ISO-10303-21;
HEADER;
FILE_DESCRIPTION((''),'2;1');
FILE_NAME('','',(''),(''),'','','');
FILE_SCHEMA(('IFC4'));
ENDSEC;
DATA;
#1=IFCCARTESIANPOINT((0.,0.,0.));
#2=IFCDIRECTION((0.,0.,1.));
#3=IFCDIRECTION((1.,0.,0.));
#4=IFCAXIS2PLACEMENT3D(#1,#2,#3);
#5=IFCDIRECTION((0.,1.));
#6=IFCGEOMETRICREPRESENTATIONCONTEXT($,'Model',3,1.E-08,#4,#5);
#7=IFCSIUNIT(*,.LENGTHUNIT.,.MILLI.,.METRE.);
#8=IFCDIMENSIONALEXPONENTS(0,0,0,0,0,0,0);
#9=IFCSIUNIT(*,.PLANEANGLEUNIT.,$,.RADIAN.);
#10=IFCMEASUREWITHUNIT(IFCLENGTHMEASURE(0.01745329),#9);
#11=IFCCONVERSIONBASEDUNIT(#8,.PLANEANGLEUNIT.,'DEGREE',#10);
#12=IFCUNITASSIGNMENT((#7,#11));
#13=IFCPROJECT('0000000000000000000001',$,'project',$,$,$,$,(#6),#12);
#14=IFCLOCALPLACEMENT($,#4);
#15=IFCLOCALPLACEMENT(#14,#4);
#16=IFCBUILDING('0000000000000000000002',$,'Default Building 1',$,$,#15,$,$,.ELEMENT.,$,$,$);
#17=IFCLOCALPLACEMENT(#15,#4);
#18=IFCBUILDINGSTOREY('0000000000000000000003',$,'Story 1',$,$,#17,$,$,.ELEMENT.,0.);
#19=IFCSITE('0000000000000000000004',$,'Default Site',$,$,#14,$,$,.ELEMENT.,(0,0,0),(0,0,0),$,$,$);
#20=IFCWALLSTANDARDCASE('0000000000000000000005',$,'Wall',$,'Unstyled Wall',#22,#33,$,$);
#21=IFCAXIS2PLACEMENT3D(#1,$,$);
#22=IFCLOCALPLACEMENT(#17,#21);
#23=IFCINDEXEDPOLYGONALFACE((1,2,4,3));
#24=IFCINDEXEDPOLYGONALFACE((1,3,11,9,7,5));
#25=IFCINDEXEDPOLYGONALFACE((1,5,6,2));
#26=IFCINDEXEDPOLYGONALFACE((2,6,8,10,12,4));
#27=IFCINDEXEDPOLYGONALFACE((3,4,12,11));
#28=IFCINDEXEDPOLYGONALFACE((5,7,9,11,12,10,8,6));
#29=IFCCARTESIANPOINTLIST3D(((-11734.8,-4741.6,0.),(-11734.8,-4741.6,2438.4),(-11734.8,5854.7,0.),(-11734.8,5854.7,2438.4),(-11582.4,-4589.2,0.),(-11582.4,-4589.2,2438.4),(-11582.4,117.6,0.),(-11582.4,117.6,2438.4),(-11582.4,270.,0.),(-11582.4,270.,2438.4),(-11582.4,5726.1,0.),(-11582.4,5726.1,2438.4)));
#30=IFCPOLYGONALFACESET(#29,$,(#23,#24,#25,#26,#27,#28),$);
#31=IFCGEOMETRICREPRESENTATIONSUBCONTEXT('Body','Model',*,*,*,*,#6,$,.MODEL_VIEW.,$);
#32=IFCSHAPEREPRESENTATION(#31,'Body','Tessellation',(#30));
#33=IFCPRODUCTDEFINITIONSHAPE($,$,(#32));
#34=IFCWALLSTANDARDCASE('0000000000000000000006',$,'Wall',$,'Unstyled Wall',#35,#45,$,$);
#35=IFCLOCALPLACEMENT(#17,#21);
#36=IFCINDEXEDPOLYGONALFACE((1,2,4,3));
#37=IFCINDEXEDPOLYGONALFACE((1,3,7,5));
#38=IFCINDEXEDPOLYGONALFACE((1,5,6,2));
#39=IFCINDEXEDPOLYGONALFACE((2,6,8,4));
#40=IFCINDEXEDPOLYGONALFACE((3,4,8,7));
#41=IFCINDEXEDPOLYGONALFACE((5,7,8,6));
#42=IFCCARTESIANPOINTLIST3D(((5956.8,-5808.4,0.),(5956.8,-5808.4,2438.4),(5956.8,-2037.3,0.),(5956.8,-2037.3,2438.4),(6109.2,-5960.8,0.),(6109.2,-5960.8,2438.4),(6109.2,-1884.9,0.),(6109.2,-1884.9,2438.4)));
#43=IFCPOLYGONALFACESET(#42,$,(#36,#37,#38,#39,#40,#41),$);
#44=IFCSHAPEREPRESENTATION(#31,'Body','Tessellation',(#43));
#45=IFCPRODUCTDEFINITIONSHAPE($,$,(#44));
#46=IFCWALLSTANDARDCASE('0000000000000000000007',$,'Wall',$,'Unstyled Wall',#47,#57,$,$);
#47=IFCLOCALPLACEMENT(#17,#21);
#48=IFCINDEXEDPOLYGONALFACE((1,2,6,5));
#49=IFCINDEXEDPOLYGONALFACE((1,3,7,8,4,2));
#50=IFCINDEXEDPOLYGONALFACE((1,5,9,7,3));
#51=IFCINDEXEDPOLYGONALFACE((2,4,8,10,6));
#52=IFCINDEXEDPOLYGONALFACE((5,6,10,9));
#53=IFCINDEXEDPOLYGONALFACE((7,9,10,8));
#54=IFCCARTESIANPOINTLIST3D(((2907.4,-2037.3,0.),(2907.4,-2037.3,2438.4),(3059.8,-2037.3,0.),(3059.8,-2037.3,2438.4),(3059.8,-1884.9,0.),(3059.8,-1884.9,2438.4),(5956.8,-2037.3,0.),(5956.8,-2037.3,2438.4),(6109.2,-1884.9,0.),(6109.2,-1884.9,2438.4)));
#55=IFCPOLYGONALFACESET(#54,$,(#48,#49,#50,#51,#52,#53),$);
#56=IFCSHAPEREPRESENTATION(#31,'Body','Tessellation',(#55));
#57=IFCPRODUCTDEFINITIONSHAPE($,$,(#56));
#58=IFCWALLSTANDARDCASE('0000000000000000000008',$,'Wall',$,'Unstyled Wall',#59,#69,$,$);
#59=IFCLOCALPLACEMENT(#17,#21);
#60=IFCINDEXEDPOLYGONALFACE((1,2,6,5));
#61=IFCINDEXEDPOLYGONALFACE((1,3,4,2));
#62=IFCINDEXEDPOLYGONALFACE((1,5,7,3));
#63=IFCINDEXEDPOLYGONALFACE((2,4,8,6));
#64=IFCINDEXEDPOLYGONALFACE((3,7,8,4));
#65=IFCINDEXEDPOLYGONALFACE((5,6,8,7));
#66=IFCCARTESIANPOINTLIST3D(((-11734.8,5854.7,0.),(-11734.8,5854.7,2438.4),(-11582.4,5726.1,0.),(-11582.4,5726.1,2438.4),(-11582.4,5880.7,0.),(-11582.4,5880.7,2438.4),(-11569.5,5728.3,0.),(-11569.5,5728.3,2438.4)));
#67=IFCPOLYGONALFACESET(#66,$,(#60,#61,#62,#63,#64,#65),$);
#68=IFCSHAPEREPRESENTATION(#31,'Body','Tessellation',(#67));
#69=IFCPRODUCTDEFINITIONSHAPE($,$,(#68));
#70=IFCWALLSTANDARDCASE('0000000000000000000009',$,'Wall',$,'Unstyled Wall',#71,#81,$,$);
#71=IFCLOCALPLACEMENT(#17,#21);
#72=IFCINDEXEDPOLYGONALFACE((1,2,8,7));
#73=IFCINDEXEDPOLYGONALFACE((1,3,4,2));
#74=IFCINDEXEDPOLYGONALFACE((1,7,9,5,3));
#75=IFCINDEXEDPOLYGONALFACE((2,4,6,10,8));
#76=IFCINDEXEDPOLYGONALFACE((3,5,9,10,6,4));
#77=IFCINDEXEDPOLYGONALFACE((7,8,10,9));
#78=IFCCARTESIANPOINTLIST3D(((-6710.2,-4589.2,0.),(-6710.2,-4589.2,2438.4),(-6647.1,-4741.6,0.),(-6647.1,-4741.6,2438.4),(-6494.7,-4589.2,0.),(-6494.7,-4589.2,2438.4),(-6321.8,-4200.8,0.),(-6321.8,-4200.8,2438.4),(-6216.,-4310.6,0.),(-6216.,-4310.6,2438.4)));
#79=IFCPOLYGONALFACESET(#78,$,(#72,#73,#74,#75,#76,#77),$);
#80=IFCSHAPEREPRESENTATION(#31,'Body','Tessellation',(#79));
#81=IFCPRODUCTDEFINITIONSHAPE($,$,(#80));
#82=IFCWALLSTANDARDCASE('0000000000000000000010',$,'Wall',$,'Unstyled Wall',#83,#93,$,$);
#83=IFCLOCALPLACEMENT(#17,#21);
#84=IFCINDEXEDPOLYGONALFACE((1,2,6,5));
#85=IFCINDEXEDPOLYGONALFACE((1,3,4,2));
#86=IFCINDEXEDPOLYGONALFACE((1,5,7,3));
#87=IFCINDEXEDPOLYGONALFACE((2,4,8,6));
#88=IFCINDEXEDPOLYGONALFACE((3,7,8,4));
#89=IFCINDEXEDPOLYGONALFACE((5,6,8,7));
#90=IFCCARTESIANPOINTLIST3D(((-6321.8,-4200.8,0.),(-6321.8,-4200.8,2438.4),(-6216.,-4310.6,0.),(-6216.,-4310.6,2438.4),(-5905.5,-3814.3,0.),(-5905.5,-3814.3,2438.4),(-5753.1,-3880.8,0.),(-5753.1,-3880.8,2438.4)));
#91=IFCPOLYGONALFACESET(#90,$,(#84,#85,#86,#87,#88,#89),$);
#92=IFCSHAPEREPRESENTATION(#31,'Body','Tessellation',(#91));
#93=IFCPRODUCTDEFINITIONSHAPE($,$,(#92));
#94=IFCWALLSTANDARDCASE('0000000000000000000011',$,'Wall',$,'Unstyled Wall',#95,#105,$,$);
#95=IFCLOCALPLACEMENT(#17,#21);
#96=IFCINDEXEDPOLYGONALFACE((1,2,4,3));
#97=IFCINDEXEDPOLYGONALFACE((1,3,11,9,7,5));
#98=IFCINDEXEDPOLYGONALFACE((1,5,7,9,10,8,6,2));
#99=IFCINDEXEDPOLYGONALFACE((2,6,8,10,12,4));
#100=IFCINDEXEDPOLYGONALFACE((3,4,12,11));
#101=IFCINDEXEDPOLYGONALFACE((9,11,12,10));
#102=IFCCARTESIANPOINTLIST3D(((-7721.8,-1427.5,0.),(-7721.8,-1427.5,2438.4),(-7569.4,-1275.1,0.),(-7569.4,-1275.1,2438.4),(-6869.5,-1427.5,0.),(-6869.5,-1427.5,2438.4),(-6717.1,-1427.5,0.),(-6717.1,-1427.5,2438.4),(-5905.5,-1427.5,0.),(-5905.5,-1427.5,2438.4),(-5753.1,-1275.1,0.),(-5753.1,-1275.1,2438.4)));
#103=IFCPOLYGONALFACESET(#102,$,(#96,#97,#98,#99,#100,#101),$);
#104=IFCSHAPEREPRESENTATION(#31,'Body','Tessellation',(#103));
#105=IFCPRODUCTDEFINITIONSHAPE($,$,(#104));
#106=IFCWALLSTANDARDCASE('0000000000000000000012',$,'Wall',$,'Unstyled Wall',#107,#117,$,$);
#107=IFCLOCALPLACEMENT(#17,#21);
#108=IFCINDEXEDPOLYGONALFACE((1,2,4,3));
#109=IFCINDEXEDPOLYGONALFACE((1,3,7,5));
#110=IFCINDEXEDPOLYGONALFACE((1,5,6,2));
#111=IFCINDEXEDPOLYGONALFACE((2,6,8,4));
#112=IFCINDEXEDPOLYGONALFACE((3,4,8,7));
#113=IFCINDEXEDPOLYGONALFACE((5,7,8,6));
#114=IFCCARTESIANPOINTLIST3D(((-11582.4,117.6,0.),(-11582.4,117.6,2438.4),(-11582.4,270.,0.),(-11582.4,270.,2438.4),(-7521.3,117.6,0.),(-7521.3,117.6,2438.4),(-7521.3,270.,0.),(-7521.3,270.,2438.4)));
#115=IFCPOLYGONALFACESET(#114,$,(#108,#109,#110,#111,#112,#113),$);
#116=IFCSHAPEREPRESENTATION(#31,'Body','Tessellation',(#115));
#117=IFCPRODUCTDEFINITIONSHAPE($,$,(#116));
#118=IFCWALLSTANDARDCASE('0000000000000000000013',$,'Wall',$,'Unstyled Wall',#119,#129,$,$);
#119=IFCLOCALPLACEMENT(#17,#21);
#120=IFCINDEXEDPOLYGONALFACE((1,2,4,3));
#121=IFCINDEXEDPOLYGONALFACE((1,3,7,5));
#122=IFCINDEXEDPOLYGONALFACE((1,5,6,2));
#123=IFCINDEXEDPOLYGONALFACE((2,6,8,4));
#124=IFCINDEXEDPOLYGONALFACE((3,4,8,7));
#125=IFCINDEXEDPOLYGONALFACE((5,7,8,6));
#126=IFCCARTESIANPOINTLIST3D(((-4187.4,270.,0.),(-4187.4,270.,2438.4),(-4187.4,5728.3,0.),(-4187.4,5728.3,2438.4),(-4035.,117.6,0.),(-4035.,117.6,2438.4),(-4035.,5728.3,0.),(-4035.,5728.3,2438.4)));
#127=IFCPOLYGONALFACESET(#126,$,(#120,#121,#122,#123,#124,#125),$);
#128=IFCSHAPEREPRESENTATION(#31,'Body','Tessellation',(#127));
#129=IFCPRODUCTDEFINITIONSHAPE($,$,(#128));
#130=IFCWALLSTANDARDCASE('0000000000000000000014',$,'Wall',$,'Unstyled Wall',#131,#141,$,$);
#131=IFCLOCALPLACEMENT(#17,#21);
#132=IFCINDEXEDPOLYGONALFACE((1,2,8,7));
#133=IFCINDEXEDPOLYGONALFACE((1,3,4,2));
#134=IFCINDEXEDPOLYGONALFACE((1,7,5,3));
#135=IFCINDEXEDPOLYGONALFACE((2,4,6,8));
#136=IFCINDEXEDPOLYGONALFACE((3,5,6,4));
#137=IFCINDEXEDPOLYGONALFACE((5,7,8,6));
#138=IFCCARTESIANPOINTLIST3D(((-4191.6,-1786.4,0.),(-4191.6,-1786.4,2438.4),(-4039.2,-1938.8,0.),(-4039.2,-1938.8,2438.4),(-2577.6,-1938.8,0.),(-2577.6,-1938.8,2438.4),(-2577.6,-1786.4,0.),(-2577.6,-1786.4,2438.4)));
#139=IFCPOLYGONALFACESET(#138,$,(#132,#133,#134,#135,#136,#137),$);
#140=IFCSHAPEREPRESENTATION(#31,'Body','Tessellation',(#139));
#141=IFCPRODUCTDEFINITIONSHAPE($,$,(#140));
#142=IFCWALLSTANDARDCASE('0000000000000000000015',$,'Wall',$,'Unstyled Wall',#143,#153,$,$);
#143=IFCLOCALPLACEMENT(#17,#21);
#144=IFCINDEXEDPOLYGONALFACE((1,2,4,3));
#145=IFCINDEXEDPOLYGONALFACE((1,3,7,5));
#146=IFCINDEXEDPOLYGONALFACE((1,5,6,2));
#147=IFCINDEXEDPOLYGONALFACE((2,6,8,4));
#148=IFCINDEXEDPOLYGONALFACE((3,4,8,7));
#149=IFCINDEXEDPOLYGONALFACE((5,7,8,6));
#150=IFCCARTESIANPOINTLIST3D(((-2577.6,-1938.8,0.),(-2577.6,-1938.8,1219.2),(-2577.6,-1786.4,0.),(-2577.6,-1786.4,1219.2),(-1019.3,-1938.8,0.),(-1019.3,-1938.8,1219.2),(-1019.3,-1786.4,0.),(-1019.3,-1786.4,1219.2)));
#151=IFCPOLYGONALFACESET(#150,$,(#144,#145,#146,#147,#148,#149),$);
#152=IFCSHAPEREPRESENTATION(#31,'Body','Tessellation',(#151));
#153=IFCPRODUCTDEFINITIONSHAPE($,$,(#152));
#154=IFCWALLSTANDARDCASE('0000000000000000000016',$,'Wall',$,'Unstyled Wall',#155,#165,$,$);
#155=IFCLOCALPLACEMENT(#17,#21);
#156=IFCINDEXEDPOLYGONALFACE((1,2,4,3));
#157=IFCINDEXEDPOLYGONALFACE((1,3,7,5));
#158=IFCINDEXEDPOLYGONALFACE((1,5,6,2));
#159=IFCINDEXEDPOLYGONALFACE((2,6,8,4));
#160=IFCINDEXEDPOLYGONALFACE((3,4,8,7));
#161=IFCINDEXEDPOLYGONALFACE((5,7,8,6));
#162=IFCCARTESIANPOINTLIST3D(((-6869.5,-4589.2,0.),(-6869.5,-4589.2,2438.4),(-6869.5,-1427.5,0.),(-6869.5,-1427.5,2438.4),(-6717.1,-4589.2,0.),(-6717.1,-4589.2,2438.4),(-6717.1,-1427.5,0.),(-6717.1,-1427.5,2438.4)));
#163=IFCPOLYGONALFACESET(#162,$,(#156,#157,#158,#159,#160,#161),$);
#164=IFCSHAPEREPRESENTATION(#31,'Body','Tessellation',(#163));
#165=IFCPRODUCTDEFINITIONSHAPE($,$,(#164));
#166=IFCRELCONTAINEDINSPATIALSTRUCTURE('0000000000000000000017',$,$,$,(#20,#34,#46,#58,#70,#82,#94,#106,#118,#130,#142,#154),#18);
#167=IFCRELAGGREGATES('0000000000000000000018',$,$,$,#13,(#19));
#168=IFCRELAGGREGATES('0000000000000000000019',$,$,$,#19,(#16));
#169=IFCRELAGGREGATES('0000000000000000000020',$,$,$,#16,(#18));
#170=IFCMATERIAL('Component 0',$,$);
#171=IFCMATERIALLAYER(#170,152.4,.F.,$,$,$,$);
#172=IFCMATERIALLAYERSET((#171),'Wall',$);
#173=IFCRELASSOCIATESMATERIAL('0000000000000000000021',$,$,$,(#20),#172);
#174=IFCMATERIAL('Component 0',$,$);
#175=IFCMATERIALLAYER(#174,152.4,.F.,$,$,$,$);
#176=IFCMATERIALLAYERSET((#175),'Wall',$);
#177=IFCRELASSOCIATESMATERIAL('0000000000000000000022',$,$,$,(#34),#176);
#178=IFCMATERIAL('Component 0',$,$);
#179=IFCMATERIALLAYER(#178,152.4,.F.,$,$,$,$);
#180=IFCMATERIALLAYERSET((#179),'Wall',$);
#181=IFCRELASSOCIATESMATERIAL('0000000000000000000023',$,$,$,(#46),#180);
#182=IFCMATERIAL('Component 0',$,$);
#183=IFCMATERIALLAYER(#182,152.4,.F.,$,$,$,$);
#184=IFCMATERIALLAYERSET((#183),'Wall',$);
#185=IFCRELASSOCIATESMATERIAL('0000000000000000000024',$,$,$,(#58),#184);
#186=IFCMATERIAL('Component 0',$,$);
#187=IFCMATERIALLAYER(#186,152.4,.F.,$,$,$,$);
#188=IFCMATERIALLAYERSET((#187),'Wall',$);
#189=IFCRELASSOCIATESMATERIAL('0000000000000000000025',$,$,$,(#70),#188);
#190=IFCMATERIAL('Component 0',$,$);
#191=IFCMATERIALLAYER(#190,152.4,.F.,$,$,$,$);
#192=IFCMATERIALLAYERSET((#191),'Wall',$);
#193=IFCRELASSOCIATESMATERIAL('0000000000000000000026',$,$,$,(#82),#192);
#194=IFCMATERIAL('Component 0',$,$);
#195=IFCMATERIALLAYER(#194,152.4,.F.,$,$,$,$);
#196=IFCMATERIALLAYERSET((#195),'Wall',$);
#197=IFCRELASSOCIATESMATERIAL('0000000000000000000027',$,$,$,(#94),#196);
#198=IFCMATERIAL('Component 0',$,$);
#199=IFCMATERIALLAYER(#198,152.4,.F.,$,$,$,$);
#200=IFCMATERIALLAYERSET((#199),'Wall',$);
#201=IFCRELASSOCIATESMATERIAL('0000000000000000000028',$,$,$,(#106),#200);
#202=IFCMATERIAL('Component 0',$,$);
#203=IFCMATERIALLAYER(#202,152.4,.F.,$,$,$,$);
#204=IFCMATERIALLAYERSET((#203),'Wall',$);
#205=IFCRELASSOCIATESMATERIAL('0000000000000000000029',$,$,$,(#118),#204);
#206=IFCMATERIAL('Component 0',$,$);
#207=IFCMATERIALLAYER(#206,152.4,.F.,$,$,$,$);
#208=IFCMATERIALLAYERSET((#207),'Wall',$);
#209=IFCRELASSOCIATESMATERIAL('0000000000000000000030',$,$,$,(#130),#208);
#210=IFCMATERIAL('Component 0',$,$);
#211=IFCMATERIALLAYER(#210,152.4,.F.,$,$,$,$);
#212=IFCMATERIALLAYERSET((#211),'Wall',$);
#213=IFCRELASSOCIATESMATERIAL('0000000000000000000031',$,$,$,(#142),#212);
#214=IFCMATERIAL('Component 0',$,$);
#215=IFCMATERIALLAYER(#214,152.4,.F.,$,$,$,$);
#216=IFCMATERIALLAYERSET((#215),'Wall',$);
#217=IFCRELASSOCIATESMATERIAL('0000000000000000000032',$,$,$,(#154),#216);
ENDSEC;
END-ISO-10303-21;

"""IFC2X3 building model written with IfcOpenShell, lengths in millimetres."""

from ifc_helpers import new_model, entity, si_unit, converted_unit, direction, frame, origin_with_axes, place, context, subcontext, project, spatial, polyline, outline, extrude, material, layer, layer_set, layer_usage, element, save


model = new_model("IFC2X3")

# Units and contexts
model_context = context("Model", 3, precision=1e-08, world=origin_with_axes(), true_north=direction((0.0, 1.0)))
body_context = subcontext(model_context, "Body", "Model", "MODEL_VIEW")
ifc_project = project(units=[si_unit("LENGTHUNIT", "METRE", prefix="MILLI"), converted_unit("PLANEANGLEUNIT", "DEGREE", entity("IfcLengthMeasure", 0.01745329), si_unit("PLANEANGLEUNIT", "RADIAN"), dimensions=[0, 0, 0, 0, 0, 0, 0])], contexts=[model_context])

# Site, building, storey
site_placement = place(None, origin_with_axes())
site = spatial("IfcSite", under=ifc_project, at=site_placement, Name="Default Site", CompositionType="ELEMENT", RefLatitude=(0, 0, 0), RefLongitude=(0, 0, 0))
building_placement = place(site_placement, origin_with_axes())
building = spatial("IfcBuilding", under=site, at=building_placement, Name="Default Building 1", CompositionType="ELEMENT")
storey_placement = place(building_placement, origin_with_axes())
storey = spatial("IfcBuildingStorey", under=building, at=storey_placement, Name="Story 1", CompositionType="ELEMENT", Elevation=0.0)

# Walls
ifc_material_1 = material(Name="Component 0")
ifc_layer_1 = layer(ifc_material_1, 152.4, ventilated=False)
ifc_layer_set_1 = layer_set([ifc_layer_1], Name="Wall")
ifc_layer_usage_1 = layer_usage(ifc_layer_set_1, "AXIS2", "POSITIVE", -76.2)
wall_1_placement = place(storey_placement, frame((-11658.6, 5790.4, 0.0), z_axis=(0.0, 0.0, 1.0), x_axis=(0.0, -1.0, 0.0)))
element("IfcWallStandardCase", 1, at=wall_1_placement, inside=storey, material=ifc_layer_usage_1, Name="Wall", ObjectType="Unstyled Wall", context=body_context, shape_type="SweptSolid", body=[
    extrude(outline(polyline([(64.3, 76.2), (-64.3, -76.2), (10532.0, -76.2), (10379.6, 76.2), (5672.8, 76.2), (5520.4, 76.2), (64.3, 76.2)])), origin_with_axes(), (0.0, 0.0, 1.0), 2438.4),
])
ifc_material_2 = material(Name="Component 0")
ifc_layer_2 = layer(ifc_material_2, 152.4, ventilated=False)
ifc_layer_set_2 = layer_set([ifc_layer_2], Name="Wall")
ifc_layer_usage_2 = layer_usage(ifc_layer_set_2, "AXIS2", "POSITIVE", -76.2)
wall_2_placement = place(storey_placement, frame((6033.0, -5884.6, 0.0), z_axis=(0.0, 0.0, 1.0), x_axis=(0.0, 1.0, 0.0)))
element("IfcWallStandardCase", 2, at=wall_2_placement, inside=storey, material=ifc_layer_usage_2, Name="Wall", ObjectType="Unstyled Wall", context=body_context, shape_type="SweptSolid", body=[
    extrude(outline(polyline([(76.2, 76.2), (-76.2, -76.2), (3999.7, -76.2), (3847.3, 76.2), (76.2, 76.2)])), origin_with_axes(), (0.0, 0.0, 1.0), 2438.4),
])
ifc_material_3 = material(Name="Component 0")
ifc_layer_3 = layer(ifc_material_3, 152.4, ventilated=False)
ifc_layer_set_3 = layer_set([ifc_layer_3], Name="Wall")
ifc_layer_usage_3 = layer_usage(ifc_layer_set_3, "AXIS2", "POSITIVE", -76.2)
wall_3_placement = place(storey_placement, frame((6033.0, -1961.1, 0.0), z_axis=(0.0, 0.0, 1.0), x_axis=(-1.0, 0.0, 0.0)))
element("IfcWallStandardCase", 3, at=wall_3_placement, inside=storey, material=ifc_layer_usage_3, Name="Wall", ObjectType="Unstyled Wall", context=body_context, shape_type="SweptSolid", body=[
    extrude(outline(polyline([(76.2, 76.2), (-76.2, -76.2), (2973.1, -76.2), (3125.5, 76.2), (2973.1, 76.2), (76.2, 76.2)])), origin_with_axes(), (0.0, 0.0, 1.0), 2438.4),
])
ifc_material_4 = material(Name="Component 0")
ifc_layer_4 = layer(ifc_material_4, 152.4, ventilated=False)
ifc_layer_set_4 = layer_set([ifc_layer_4], Name="Wall")
ifc_layer_usage_4 = layer_usage(ifc_layer_set_4, "AXIS2", "POSITIVE", -76.2)
wall_4_placement = place(storey_placement, frame((-11575.9, 5804.5, 0.0), z_axis=(0.0, 0.0, 1.0), x_axis=(-0.985769, -0.168107, 0.0)))
element("IfcWallStandardCase", 4, at=wall_4_placement, inside=storey, material=ifc_layer_usage_4, Name="Wall", ObjectType="Unstyled Wall", context=body_context, shape_type="SweptSolid", body=[
    extrude(outline(polyline([(6.5, 76.2), (-6.5, -76.2), (148.1, -76.2), (19.5, 76.2), (6.5, 76.2)])), origin_with_axes(), (0.0, 0.0, 1.0), 2438.4),
])
ifc_material_5 = material(Name="Component 0")
ifc_layer_5 = layer(ifc_material_5, 152.4, ventilated=False)
ifc_layer_set_5 = layer_set([ifc_layer_5], Name="Wall")
ifc_layer_usage_5 = layer_usage(ifc_layer_set_5, "AXIS2", "POSITIVE", -76.2)
wall_5_placement = place(storey_placement, frame((-6678.6, -4665.4, 0.0), z_axis=(0.0, 0.0, 1.0), x_axis=(0.707107, 0.707107, 0.0)))
element("IfcWallStandardCase", 5, at=wall_5_placement, inside=storey, material=ifc_layer_usage_5, Name="Wall", ObjectType="Unstyled Wall", context=body_context, shape_type="SweptSolid", body=[
    extrude(outline(polyline([(-31.6, -76.2), (184.0, -76.2), (578.0, -76.2), (580.9, 76.2), (31.6, 76.2), (-31.6, -76.2)])), origin_with_axes(), (0.0, 0.0, 1.0), 2438.4),
])
ifc_material_6 = material(Name="Component 0")
ifc_layer_6 = layer(ifc_material_6, 152.4, ventilated=False)
ifc_layer_set_6 = layer_set([ifc_layer_6], Name="Wall")
ifc_layer_usage_6 = layer_usage(ifc_layer_set_6, "AXIS2", "POSITIVE", -76.2)
wall_6_placement = place(storey_placement, frame((-6268.9, -4255.7, 0.0), z_axis=(0.0, 0.0, 1.0), x_axis=(0.732826, 0.680416, 0.0)))
element("IfcWallStandardCase", 6, at=wall_6_placement, inside=storey, material=ifc_layer_usage_6, Name="Wall", ObjectType="Unstyled Wall", context=body_context, shape_type="SweptSolid", body=[
    extrude(outline(polyline([(-1.4, 76.2), (1.4, -76.2), (633.1, -76.2), (566.6, 76.2), (-1.4, 76.2)])), origin_with_axes(), (0.0, 0.0, 1.0), 2438.4),
])
ifc_material_7 = material(Name="Component 0")
ifc_layer_7 = layer(ifc_material_7, 152.4, ventilated=False)
ifc_layer_set_7 = layer_set([ifc_layer_7], Name="Wall")
ifc_layer_usage_7 = layer_usage(ifc_layer_set_7, "AXIS2", "POSITIVE", -76.2)
wall_7_placement = place(storey_placement, frame((-5829.3, -1351.3, 0.0), z_axis=(0.0, 0.0, 1.0), x_axis=(-1.0, 0.0, 0.0)))
element("IfcWallStandardCase", 7, at=wall_7_placement, inside=storey, material=ifc_layer_usage_7, Name="Wall", ObjectType="Unstyled Wall", context=body_context, shape_type="SweptSolid", body=[
    extrude(outline(polyline([(76.2, 76.2), (-76.2, -76.2), (1740.1, -76.2), (1892.5, 76.2), (1040.2, 76.2), (887.8, 76.2), (76.2, 76.2)])), origin_with_axes(), (0.0, 0.0, 1.0), 2438.4),
])
ifc_material_8 = material(Name="Component 0")
ifc_layer_8 = layer(ifc_material_8, 152.4, ventilated=False)
ifc_layer_set_8 = layer_set([ifc_layer_8], Name="Wall")
ifc_layer_usage_8 = layer_usage(ifc_layer_set_8, "AXIS2", "POSITIVE", -76.2)
wall_8_placement = place(storey_placement, frame((-7521.3, 193.8, 0.0), z_axis=(0.0, 0.0, 1.0), x_axis=(-1.0, 0.0, 0.0)))
element("IfcWallStandardCase", 8, at=wall_8_placement, inside=storey, material=ifc_layer_usage_8, Name="Wall", ObjectType="Unstyled Wall", context=body_context, shape_type="SweptSolid", body=[
    extrude(outline(polyline([(0.0, 76.2), (0.0, -76.2), (4061.1, -76.2), (4061.1, 76.2), (0.0, 76.2)])), origin_with_axes(), (0.0, 0.0, 1.0), 2438.4),
])
ifc_material_9 = material(Name="Component 0")
ifc_layer_9 = layer(ifc_material_9, 152.4, ventilated=False)
ifc_layer_set_9 = layer_set([ifc_layer_9], Name="Wall")
ifc_layer_usage_9 = layer_usage(ifc_layer_set_9, "AXIS2", "POSITIVE", -76.2)
wall_9_placement = place(storey_placement, frame((-4111.2, 193.8, 0.0), z_axis=(0.0, 0.0, 1.0), x_axis=(0.0, 1.0, 0.0)))
element("IfcWallStandardCase", 9, at=wall_9_placement, inside=storey, material=ifc_layer_usage_9, Name="Wall", ObjectType="Unstyled Wall", context=body_context, shape_type="SweptSolid", body=[
    extrude(outline(polyline([(76.2, 76.2), (-76.2, -76.2), (5534.5, -76.2), (5534.5, 76.2), (76.2, 76.2)])), origin_with_axes(), (0.0, 0.0, 1.0), 2438.4),
])
ifc_material_10 = material(Name="Component 0")
ifc_layer_10 = layer(ifc_material_10, 152.4, ventilated=False)
ifc_layer_set_10 = layer_set([ifc_layer_10], Name="Wall")
ifc_layer_usage_10 = layer_usage(ifc_layer_set_10, "AXIS2", "POSITIVE", -76.2)
wall_10_placement = place(storey_placement, frame((-4115.4, -1862.6, 0.0), z_axis=(0.0, 0.0, 1.0), x_axis=(1.0, 0.0, 0.0)))
element("IfcWallStandardCase", 10, at=wall_10_placement, inside=storey, material=ifc_layer_usage_10, Name="Wall", ObjectType="Unstyled Wall", context=body_context, shape_type="SweptSolid", body=[
    extrude(outline(polyline([(1537.8, 76.2), (-76.2, 76.2), (76.2, -76.2), (1537.8, -76.2), (1537.8, 76.2)])), origin_with_axes(), (0.0, 0.0, 1.0), 2438.4),
])
ifc_material_11 = material(Name="Component 0")
ifc_layer_11 = layer(ifc_material_11, 152.4, ventilated=False)
ifc_layer_set_11 = layer_set([ifc_layer_11], Name="Wall")
ifc_layer_usage_11 = layer_usage(ifc_layer_set_11, "AXIS2", "POSITIVE", -76.2)
wall_11_placement = place(storey_placement, frame((-2577.6, -1862.6, 0.0), z_axis=(0.0, 0.0, 1.0), x_axis=(1.0, 0.0, 0.0)))
element("IfcWallStandardCase", 11, at=wall_11_placement, inside=storey, material=ifc_layer_usage_11, Name="Wall", ObjectType="Unstyled Wall", context=body_context, shape_type="SweptSolid", body=[
    extrude(outline(polyline([(1558.3, 76.2), (0.0, 76.2), (0.0, -76.2), (1558.3, -76.2), (1558.3, 76.2)])), origin_with_axes(), (0.0, 0.0, 1.0), 1219.2),
])
ifc_material_12 = material(Name="Component 0")
ifc_layer_12 = layer(ifc_material_12, 152.4, ventilated=False)
ifc_layer_set_12 = layer_set([ifc_layer_12], Name="Wall")
ifc_layer_usage_12 = layer_usage(ifc_layer_set_12, "AXIS2", "POSITIVE", -76.2)
wall_12_placement = place(storey_placement, frame((-6793.3, -4665.4, 0.0), z_axis=(0.0, 0.0, 1.0), x_axis=(0.0, 1.0, 0.0)))
element("IfcWallStandardCase", 12, at=wall_12_placement, inside=storey, material=ifc_layer_usage_12, Name="Wall", ObjectType="Unstyled Wall", context=body_context, shape_type="SweptSolid", body=[
    extrude(outline(polyline([(76.2, 76.2), (76.2, -76.2), (3237.9, -76.2), (3237.9, 76.2), (76.2, 76.2)])), origin_with_axes(), (0.0, 0.0, 1.0), 2438.4),
])

save(model, "model.ifc")
